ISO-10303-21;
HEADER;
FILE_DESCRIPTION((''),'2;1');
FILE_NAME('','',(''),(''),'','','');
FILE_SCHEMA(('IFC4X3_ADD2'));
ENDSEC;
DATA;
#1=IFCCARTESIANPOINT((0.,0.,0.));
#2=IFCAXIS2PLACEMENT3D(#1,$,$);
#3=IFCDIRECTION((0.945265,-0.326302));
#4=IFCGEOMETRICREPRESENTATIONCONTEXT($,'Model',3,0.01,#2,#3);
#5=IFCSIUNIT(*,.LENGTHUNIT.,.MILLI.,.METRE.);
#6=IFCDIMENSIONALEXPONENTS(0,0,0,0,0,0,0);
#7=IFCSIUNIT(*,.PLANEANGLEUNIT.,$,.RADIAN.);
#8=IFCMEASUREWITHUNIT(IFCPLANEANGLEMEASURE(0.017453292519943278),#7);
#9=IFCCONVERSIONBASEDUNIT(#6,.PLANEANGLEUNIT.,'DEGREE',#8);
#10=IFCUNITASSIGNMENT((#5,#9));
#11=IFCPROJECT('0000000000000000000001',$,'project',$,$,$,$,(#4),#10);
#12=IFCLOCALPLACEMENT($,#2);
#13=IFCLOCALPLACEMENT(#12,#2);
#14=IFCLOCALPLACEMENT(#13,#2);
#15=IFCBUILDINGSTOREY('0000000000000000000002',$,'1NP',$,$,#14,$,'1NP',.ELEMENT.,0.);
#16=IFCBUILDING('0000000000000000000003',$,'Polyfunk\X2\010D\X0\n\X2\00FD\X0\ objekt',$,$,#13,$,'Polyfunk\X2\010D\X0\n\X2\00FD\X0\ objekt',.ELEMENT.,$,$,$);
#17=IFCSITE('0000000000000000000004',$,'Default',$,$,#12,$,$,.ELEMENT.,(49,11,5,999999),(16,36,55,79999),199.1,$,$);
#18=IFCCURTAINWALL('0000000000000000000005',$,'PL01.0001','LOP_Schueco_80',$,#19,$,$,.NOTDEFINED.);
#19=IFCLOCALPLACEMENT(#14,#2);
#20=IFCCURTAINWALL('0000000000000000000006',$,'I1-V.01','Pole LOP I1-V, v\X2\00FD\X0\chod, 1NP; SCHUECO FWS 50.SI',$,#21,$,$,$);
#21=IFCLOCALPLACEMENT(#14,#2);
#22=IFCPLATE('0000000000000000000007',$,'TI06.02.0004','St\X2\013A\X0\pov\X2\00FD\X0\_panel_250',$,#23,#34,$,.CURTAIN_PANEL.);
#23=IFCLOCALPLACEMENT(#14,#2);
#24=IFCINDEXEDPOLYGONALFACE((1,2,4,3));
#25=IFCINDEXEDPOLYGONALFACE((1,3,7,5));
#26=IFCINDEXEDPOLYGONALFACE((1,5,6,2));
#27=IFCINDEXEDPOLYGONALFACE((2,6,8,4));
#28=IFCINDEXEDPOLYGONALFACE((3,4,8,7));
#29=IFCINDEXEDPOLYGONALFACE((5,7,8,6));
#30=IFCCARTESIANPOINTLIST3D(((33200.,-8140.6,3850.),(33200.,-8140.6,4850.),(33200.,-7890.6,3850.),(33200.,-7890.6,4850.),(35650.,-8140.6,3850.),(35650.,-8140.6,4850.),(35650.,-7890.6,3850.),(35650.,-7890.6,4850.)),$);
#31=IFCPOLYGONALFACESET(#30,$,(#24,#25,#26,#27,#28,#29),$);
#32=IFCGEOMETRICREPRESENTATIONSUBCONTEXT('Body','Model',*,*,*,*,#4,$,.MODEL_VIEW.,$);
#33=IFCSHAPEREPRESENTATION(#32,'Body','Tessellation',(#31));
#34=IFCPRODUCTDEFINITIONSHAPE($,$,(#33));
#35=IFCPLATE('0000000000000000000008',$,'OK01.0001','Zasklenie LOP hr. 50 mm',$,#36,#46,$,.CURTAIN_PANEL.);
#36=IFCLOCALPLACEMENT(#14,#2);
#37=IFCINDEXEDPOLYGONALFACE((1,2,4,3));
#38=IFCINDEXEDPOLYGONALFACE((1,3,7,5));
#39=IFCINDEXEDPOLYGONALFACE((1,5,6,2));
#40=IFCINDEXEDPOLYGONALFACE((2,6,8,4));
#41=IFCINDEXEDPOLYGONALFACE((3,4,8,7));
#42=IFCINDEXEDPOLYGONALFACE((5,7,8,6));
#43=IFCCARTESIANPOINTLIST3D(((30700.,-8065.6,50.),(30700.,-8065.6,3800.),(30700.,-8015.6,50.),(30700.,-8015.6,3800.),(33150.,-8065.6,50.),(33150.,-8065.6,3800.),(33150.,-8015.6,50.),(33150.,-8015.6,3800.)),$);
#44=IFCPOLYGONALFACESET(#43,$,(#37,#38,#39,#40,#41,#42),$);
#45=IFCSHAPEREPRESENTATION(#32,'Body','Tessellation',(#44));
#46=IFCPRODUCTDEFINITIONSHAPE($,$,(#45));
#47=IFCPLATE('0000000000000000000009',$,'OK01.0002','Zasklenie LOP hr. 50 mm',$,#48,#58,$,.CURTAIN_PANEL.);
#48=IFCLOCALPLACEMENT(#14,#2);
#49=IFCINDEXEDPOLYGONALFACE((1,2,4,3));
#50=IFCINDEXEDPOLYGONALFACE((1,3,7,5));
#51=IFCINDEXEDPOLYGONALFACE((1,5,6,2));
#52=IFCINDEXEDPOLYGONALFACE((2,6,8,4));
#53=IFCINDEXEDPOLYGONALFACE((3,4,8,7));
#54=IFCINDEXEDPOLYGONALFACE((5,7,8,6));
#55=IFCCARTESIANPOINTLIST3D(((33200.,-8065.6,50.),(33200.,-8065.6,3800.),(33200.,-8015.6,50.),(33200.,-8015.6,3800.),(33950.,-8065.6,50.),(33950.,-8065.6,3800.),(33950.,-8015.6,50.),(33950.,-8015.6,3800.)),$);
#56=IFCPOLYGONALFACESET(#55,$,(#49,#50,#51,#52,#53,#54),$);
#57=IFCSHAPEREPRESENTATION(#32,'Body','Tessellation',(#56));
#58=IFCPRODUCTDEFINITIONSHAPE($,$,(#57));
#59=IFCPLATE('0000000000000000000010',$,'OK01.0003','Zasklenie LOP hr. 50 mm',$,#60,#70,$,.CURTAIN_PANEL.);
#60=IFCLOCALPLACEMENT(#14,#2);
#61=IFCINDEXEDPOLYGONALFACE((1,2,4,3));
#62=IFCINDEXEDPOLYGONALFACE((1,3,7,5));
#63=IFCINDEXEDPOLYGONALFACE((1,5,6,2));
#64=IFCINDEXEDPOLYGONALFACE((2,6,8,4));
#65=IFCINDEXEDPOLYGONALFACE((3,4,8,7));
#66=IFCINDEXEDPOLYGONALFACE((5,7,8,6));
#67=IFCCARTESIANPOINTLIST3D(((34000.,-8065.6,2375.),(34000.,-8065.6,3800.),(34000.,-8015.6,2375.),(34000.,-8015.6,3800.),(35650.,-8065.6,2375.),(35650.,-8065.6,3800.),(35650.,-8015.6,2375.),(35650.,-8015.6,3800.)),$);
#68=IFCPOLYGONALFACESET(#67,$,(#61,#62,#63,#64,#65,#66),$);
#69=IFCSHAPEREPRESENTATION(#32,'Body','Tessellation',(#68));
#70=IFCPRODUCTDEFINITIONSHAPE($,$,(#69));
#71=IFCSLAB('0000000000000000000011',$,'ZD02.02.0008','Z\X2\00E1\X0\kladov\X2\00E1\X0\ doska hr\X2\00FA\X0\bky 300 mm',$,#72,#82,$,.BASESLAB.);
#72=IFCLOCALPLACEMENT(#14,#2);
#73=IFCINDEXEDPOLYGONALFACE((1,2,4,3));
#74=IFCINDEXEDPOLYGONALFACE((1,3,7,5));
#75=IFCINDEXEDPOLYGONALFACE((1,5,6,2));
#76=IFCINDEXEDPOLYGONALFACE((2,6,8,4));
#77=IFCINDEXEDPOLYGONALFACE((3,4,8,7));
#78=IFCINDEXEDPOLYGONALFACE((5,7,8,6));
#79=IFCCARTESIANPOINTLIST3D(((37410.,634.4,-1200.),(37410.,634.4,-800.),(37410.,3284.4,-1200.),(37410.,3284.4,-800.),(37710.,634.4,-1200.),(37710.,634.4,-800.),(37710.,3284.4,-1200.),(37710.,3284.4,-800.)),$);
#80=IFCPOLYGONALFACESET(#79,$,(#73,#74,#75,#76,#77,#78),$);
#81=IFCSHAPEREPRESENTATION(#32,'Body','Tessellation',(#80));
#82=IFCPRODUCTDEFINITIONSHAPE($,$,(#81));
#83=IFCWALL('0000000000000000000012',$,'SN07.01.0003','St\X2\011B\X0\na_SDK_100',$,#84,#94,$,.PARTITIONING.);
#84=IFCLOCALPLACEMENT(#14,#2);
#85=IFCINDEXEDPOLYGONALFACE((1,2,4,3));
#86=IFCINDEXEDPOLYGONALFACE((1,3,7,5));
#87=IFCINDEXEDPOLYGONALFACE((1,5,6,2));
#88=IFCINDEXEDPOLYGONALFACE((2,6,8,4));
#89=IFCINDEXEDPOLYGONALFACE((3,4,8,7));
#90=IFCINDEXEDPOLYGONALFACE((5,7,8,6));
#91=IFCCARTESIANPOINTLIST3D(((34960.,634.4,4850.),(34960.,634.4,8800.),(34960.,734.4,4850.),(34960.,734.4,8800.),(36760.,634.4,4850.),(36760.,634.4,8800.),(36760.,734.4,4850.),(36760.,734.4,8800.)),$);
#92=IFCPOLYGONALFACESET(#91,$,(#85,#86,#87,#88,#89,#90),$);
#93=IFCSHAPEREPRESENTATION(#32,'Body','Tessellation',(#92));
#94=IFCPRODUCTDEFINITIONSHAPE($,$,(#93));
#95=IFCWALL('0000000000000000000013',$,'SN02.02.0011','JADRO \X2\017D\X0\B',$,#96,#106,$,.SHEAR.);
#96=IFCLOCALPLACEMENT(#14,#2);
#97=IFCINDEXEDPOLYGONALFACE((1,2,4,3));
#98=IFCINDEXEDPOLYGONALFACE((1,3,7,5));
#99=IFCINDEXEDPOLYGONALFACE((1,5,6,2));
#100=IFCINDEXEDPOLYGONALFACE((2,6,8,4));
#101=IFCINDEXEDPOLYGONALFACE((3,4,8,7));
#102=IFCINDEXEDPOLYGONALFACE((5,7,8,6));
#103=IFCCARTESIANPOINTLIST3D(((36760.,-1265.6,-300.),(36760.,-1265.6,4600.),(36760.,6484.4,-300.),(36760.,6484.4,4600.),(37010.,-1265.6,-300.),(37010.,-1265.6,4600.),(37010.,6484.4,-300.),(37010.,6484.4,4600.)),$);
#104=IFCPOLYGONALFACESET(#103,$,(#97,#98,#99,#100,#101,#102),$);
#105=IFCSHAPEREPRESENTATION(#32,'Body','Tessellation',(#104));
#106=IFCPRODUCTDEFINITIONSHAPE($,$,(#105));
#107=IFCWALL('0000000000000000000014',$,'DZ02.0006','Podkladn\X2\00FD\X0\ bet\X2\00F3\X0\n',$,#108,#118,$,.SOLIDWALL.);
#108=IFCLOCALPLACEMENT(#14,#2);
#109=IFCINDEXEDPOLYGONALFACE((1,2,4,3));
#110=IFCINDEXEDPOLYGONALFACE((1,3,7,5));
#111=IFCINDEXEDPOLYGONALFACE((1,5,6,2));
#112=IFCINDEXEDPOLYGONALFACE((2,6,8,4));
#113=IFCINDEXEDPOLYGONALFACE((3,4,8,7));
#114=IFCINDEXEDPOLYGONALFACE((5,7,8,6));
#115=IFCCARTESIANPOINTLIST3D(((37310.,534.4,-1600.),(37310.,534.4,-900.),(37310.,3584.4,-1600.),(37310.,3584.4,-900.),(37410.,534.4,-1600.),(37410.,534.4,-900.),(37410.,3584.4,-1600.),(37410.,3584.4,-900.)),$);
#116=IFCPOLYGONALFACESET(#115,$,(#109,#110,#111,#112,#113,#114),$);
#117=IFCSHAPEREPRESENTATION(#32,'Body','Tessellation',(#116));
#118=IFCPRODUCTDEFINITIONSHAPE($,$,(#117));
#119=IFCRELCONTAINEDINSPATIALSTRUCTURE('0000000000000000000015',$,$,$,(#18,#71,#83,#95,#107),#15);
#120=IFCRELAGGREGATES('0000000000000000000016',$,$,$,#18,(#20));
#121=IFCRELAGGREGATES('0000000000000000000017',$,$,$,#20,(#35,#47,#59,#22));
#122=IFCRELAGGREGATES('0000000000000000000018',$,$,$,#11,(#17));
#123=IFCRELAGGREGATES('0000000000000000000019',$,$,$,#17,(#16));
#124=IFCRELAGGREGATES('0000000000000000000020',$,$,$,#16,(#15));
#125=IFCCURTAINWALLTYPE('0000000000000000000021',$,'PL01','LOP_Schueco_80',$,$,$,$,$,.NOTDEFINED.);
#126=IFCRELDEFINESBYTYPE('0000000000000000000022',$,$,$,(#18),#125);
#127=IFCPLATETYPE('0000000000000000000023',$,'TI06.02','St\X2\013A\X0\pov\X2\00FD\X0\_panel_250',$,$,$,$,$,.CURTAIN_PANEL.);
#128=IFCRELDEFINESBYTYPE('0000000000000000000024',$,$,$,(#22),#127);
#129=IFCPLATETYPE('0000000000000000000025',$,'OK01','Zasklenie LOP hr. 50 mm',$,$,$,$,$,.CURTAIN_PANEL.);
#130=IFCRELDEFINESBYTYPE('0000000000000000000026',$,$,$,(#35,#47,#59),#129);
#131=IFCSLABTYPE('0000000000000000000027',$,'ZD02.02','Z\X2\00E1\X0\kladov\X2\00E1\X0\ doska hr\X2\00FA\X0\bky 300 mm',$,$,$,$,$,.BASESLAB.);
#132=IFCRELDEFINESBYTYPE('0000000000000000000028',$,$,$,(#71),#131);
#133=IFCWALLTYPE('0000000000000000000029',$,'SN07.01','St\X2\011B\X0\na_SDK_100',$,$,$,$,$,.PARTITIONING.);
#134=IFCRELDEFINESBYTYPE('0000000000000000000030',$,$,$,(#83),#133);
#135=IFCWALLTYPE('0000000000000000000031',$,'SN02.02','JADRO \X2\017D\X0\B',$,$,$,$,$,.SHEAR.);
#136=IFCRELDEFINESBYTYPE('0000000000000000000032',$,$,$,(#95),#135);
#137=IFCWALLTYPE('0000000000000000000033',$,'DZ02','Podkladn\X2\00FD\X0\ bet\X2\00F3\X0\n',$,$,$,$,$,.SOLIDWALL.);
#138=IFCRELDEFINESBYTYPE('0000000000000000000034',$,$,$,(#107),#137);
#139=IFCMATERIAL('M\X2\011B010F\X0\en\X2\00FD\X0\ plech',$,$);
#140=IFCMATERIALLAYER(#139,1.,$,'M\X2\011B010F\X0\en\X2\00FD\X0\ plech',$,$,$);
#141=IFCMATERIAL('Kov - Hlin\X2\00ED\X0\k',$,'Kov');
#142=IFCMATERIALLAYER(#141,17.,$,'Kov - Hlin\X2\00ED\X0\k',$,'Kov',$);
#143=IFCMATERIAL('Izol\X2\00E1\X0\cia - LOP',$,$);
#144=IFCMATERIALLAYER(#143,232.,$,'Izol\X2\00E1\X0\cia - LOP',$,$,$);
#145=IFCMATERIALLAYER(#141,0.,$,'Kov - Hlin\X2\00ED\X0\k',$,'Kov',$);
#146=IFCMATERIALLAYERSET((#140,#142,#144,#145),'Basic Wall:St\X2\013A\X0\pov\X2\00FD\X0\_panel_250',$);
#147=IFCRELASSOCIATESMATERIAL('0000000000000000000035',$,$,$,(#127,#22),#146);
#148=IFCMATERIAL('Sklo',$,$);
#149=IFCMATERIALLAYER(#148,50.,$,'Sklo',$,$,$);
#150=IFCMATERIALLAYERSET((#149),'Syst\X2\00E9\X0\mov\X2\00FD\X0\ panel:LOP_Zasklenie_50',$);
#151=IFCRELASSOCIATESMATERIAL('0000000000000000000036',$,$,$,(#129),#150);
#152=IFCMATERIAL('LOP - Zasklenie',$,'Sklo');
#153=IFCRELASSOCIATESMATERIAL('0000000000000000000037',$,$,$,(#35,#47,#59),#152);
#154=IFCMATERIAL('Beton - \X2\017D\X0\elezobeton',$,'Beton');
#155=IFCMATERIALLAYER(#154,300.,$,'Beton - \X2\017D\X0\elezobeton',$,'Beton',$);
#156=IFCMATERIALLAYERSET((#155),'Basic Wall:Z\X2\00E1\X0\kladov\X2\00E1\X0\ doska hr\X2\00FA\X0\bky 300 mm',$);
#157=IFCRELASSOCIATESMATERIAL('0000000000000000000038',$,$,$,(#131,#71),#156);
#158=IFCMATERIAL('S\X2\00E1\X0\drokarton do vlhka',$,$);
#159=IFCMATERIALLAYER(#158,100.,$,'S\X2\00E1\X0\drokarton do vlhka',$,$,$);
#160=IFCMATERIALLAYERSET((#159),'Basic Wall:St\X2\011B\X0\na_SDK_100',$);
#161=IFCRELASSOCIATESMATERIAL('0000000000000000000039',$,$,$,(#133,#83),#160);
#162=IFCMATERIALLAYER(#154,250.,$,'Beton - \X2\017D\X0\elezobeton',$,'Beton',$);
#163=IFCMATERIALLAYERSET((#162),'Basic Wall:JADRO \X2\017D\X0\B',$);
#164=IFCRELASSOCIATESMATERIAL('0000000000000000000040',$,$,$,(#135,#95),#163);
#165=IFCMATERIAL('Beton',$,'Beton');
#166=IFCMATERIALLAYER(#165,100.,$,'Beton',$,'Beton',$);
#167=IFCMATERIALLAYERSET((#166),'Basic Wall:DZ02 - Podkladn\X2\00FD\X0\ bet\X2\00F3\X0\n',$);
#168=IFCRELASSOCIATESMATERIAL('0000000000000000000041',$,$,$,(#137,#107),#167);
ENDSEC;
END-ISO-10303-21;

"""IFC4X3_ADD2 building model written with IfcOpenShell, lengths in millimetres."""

from ifc_helpers import new_model, entity, si_unit, converted_unit, direction, frame, frame_2d, origin, place, context, subcontext, project, spatial, polyline, rectangle, extrude, clip, bounded_halfspace, source, transform, mapped, material, layer, layer_set, layer_usage, type_object, type_shapes, element, aggregate, save


model = new_model("IFC4X3_ADD2")

# Units and contexts
model_context = context("Model", 3, precision=0.01, world=origin(), true_north=direction((0.945265, -0.326302)))
body_context = subcontext(model_context, "Body", "Model", "MODEL_VIEW")
ifc_project = project(units=[si_unit("LENGTHUNIT", "METRE", prefix="MILLI"), converted_unit("PLANEANGLEUNIT", "DEGREE", entity("IfcPlaneAngleMeasure", 0.017453292519943278), si_unit("PLANEANGLEUNIT", "RADIAN"), dimensions=[0, 0, 0, 0, 0, 0, 0])], contexts=[model_context])

# Site, building, storey
site_placement = place(None, origin())
site = spatial("IfcSite", under=ifc_project, at=site_placement, Name="Default", CompositionType="ELEMENT", RefLatitude=(49, 11, 5, 999999), RefLongitude=(16, 36, 55, 79999), RefElevation=199.1)
building_placement = place(site_placement, origin())
building = spatial("IfcBuilding", under=site, at=building_placement, Name="Polyfunkčný objekt", LongName="Polyfunkčný objekt", CompositionType="ELEMENT")
storey_placement = place(building_placement, origin())
storey = spatial("IfcBuildingStorey", under=building, at=storey_placement, Name="1NP", LongName="1NP", CompositionType="ELEMENT", Elevation=0.0)

# Curtain walls, plates
curtain_wall_type = type_object("IfcCurtainWallType", Name="PL01", Description="LOP_Schueco_80", PredefinedType="NOTDEFINED")
curtain_wall_1_placement = place(storey_placement, origin())
curtain_wall_1 = element("IfcCurtainWall", 1, at=curtain_wall_1_placement, inside=storey, type_object=curtain_wall_type, Name="PL01.0001", Description="LOP_Schueco_80", PredefinedType="NOTDEFINED")
curtain_wall_2 = element("IfcCurtainWall", 2, Name="I1-V.01", Description="Pole LOP I1-V, východ, 1NP; SCHUECO FWS 50.SI")
aggregate(curtain_wall_1, [curtain_wall_2])
ifc_material_1 = material(Name="Měďený plech")
ifc_layer_1 = layer(ifc_material_1, 1.0, Name="Měďený plech")
ifc_material_2 = material(Name="Kov - Hliník", Category="Kov")
ifc_layer_2 = layer(ifc_material_2, 17.0, Name="Kov - Hliník", Category="Kov")
ifc_material_3 = material(Name="Izolácia - LOP")
ifc_layer_3 = layer(ifc_material_3, 232.0, Name="Izolácia - LOP")
ifc_layer_4 = layer(ifc_material_2, 0.0, Name="Kov - Hliník", Category="Kov")
ifc_layer_set_1 = layer_set([ifc_layer_1, ifc_layer_2, ifc_layer_3, ifc_layer_4], Name="Basic Wall:Stĺpový_panel_250")
ifc_layer_usage_1 = layer_usage(ifc_layer_set_1, "AXIS2", "POSITIVE", -125.0)
plate_type_1 = type_object("IfcPlateType", Name="TI06.02", Description="Stĺpový_panel_250", PredefinedType="CURTAIN_PANEL", material=ifc_layer_set_1)
plate_1_placement = place(storey_placement, frame((33200.0, -8015.6, 3850.0)))
plate_1 = element("IfcPlate", 3, at=plate_1_placement, type_object=plate_type_1, material=ifc_layer_usage_1, Name="TI06.02.0004", Description="Stĺpový_panel_250", PredefinedType="CURTAIN_PANEL", context=body_context, shape_type="SweptSolid", body=[
    extrude(rectangle(XDim=250.0, YDim=2450.0, at=frame_2d((0.0, 0.0), x_axis=(1.0, 0.0))), frame((1225.0, 0.0, 0.0), z_axis=(0.0, 0.0, 1.0), x_axis=(0.0, 1.0, 0.0)), (0.0, 0.0, 1.0), 1000.0),
])
ifc_material_4 = material(Name="LOP - Zasklenie", Category="Sklo")
ifc_material_5 = material(Name="Sklo")
ifc_layer_5 = layer(ifc_material_5, 50.0, Name="Sklo")
ifc_layer_set_2 = layer_set([ifc_layer_5], Name="Systémový panel:LOP_Zasklenie_50")
plate_type_2 = type_object("IfcPlateType", Name="OK01", Description="Zasklenie LOP hr. 50 mm", PredefinedType="CURTAIN_PANEL", material=ifc_layer_set_2)
shared_shape_1 = source(origin(), body_context, "Body", "SweptSolid", [
    extrude(rectangle(XDim=3750.0, YDim=2450.0, at=frame_2d((-331.2, 0.0), x_axis=(1.0, 0.0))), frame((0.0, -50.0, 2206.2), z_axis=(0.0, 1.0, 0.0), x_axis=(0.0, 0.0, 1.0)), (0.0, 0.0, 1.0), 50.0),
])
plate_2_placement = place(curtain_wall_1_placement, frame((31925.0, -8015.6, 50.0)))
plate_2 = element("IfcPlate", 4, at=plate_2_placement, type_object=plate_type_2, material=ifc_material_4, Name="OK01.0001", Description="Zasklenie LOP hr. 50 mm", PredefinedType="CURTAIN_PANEL", context=body_context, shape_type="MappedRepresentation", body=[
    mapped(shared_shape_1, transform((0.0, 0.0, 0.0), scale=1.0)),
])
shared_shape_2 = source(origin(), body_context, "Body", "SweptSolid", [
    extrude(rectangle(XDim=3750.0, YDim=750.0, at=frame_2d((-331.2, 0.0), x_axis=(1.0, 0.0))), frame((0.0, -50.0, 2206.2), z_axis=(0.0, 1.0, 0.0), x_axis=(0.0, 0.0, 1.0)), (0.0, 0.0, 1.0), 50.0),
])
plate_3_placement = place(curtain_wall_1_placement, frame((33575.0, -8015.6, 50.0)))
plate_3 = element("IfcPlate", 5, at=plate_3_placement, type_object=plate_type_2, material=ifc_material_4, Name="OK01.0002", Description="Zasklenie LOP hr. 50 mm", PredefinedType="CURTAIN_PANEL", context=body_context, shape_type="MappedRepresentation", body=[
    mapped(shared_shape_2, transform((0.0, 0.0, 0.0), scale=1.0)),
])
shared_shape_3 = source(origin(), body_context, "Body", "SweptSolid", [
    extrude(rectangle(XDim=1425.0, YDim=1650.0, at=frame_2d((87.6, 0.0), x_axis=(1.0, 0.0))), frame((0.0, -50.0, 624.9), z_axis=(0.0, 1.0, 0.0), x_axis=(0.0, 0.0, 1.0)), (0.0, 0.0, 1.0), 50.0),
])
type_shapes(plate_type_2, [shared_shape_1, shared_shape_2, shared_shape_3])
plate_4_placement = place(curtain_wall_1_placement, frame((34825.0, -8015.6, 2375.0)))
plate_4 = element("IfcPlate", 6, at=plate_4_placement, type_object=plate_type_2, material=ifc_material_4, Name="OK01.0003", Description="Zasklenie LOP hr. 50 mm", PredefinedType="CURTAIN_PANEL", context=body_context, shape_type="MappedRepresentation", body=[
    mapped(shared_shape_3, transform((0.0, 0.0, 0.0), scale=1.0)),
])
aggregate(curtain_wall_2, [plate_2, plate_3, plate_4, plate_1])

# Slab
ifc_material_6 = material(Name="Beton - Železobeton", Category="Beton")
ifc_layer_6 = layer(ifc_material_6, 300.0, Name="Beton - Železobeton", Category="Beton")
ifc_layer_set_3 = layer_set([ifc_layer_6], Name="Basic Wall:Základová doska hrúbky 300 mm")
slab_type = type_object("IfcSlabType", Name="ZD02.02", Description="Základová doska hrúbky 300 mm", PredefinedType="BASESLAB", material=ifc_layer_set_3)
slab_placement = place(storey_placement, frame((37560.0, 634.4, -1200.0), z_axis=(0.0, 0.0, 1.0), x_axis=(0.0, 1.0, 0.0)))
element("IfcSlab", 7, at=slab_placement, inside=storey, type_object=slab_type, material=ifc_layer_set_3, Name="ZD02.02.0008", Description="Základová doska hrúbky 300 mm", PredefinedType="BASESLAB", context=body_context, shape_type="SweptSolid", body=[
    extrude(rectangle(XDim=2650.0, YDim=300.0, at=frame_2d((1325.0, 0.0), x_axis=(-1.0, 0.0))), origin(), (0.0, 0.0, 1.0), 400.0),
])

# Walls
ifc_material_7 = material(Name="Sádrokarton do vlhka")
ifc_layer_7 = layer(ifc_material_7, 100.0, Name="Sádrokarton do vlhka")
ifc_layer_set_4 = layer_set([ifc_layer_7], Name="Basic Wall:Stěna_SDK_100")
wall_type_1 = type_object("IfcWallType", Name="SN07.01", Description="Stěna_SDK_100", PredefinedType="PARTITIONING", material=ifc_layer_set_4)
wall_1_placement = place(storey_placement, frame((34960.0, 684.4, 4850.0)))
element("IfcWall", 8, at=wall_1_placement, inside=storey, type_object=wall_type_1, material=ifc_layer_set_4, Name="SN07.01.0003", Description="Stěna_SDK_100", PredefinedType="PARTITIONING", context=body_context, shape_type="Clipping", body=[
    clip(clip(extrude(rectangle(XDim=1800.0, YDim=100.0, at=frame_2d((900.0, 0.0), x_axis=(-1.0, 0.0))), origin(), (0.0, 0.0, 1.0), 3950.0), bounded_halfspace(frame((1800.0, -50.0, 0.0), z_axis=(0.0, 0.0, 1.0), x_axis=(-1.0, 0.0, 0.0)), True, frame((1800.0, -50.0, 0.0)), polyline([(0.0, 0.0), (0.0, 100.0), (-1800.0, 100.0), (-1800.0, 0.0), (0.0, 0.0)]))), bounded_halfspace(frame((0.0, -50.0, 3950.0), z_axis=(0.0, 0.0, -1.0), x_axis=(1.0, 0.0, 0.0)), True, frame((0.0, -50.0, 3950.0)), polyline([(0.0, 0.0), (1800.0, 0.0), (1800.0, 100.0), (0.0, 100.0), (0.0, 0.0)]))),
])
ifc_layer_8 = layer(ifc_material_6, 250.0, Name="Beton - Železobeton", Category="Beton")
ifc_layer_set_5 = layer_set([ifc_layer_8], Name="Basic Wall:JADRO ŽB")
wall_type_2 = type_object("IfcWallType", Name="SN02.02", Description="JADRO ŽB", PredefinedType="SHEAR", material=ifc_layer_set_5)
wall_2_placement = place(storey_placement, frame((36885.0, -1265.6, -300.0), z_axis=(0.0, 0.0, 1.0), x_axis=(0.0, 1.0, 0.0)))
element("IfcWall", 9, at=wall_2_placement, inside=storey, type_object=wall_type_2, material=ifc_layer_set_5, Name="SN02.02.0011", Description="JADRO ŽB", PredefinedType="SHEAR", context=body_context, shape_type="Clipping", body=[
    clip(clip(extrude(rectangle(XDim=7750.0, YDim=250.0, at=frame_2d((3875.0, 0.0), x_axis=(-1.0, 0.0))), origin(), (0.0, 0.0, 1.0), 4900.0), bounded_halfspace(frame((7750.0, 125.0, 4900.0), z_axis=(0.0, 0.0, -1.0), x_axis=(0.0, -1.0, 0.0)), True, frame((7750.0, 125.0, 4900.0)), polyline([(0.0, 0.0), (-7750.0, 0.0), (-7750.0, -250.0), (-7500.0, -250.0), (-5800.0, -250.0), (-5550.0, -250.0), (-3200.0, -250.0), (-2950.0, -250.0), (-250.0, -250.0), (0.0, -250.0), (0.0, 0.0)]))), bounded_halfspace(frame((7750.0, -125.0, 0.0)), True, frame((7750.0, -125.0, 0.0)), polyline([(0.0, 0.0), (0.0, 250.0), (-390.0, 250.0), (-7750.0, 250.0), (-7750.0, 0.0), (-7500.0, 0.0), (-5800.0, 0.0), (-5550.0, 0.0), (-3200.0, 0.0), (-2950.0, 0.0), (-250.0, 0.0), (0.0, 0.0)]))),
])
ifc_material_8 = material(Name="Beton", Category="Beton")
ifc_layer_9 = layer(ifc_material_8, 100.0, Name="Beton", Category="Beton")
ifc_layer_set_6 = layer_set([ifc_layer_9], Name="Basic Wall:DZ02 - Podkladný betón")
wall_type_3 = type_object("IfcWallType", Name="DZ02", Description="Podkladný betón", PredefinedType="SOLIDWALL", material=ifc_layer_set_6)
wall_3_placement = place(storey_placement, frame((37360.0, 534.4, -1600.0), z_axis=(0.0, 0.0, 1.0), x_axis=(0.0, 1.0, 0.0)))
element("IfcWall", 10, at=wall_3_placement, inside=storey, type_object=wall_type_3, material=ifc_layer_set_6, Name="DZ02.0006", Description="Podkladný betón", PredefinedType="SOLIDWALL", context=body_context, shape_type="SweptSolid", body=[
    extrude(rectangle(XDim=3050.0, YDim=100.0, at=frame_2d((1525.0, 0.0), x_axis=(-1.0, 0.0))), origin(), (0.0, 0.0, 1.0), 700.0),
])

save(model, "model.ifc")
